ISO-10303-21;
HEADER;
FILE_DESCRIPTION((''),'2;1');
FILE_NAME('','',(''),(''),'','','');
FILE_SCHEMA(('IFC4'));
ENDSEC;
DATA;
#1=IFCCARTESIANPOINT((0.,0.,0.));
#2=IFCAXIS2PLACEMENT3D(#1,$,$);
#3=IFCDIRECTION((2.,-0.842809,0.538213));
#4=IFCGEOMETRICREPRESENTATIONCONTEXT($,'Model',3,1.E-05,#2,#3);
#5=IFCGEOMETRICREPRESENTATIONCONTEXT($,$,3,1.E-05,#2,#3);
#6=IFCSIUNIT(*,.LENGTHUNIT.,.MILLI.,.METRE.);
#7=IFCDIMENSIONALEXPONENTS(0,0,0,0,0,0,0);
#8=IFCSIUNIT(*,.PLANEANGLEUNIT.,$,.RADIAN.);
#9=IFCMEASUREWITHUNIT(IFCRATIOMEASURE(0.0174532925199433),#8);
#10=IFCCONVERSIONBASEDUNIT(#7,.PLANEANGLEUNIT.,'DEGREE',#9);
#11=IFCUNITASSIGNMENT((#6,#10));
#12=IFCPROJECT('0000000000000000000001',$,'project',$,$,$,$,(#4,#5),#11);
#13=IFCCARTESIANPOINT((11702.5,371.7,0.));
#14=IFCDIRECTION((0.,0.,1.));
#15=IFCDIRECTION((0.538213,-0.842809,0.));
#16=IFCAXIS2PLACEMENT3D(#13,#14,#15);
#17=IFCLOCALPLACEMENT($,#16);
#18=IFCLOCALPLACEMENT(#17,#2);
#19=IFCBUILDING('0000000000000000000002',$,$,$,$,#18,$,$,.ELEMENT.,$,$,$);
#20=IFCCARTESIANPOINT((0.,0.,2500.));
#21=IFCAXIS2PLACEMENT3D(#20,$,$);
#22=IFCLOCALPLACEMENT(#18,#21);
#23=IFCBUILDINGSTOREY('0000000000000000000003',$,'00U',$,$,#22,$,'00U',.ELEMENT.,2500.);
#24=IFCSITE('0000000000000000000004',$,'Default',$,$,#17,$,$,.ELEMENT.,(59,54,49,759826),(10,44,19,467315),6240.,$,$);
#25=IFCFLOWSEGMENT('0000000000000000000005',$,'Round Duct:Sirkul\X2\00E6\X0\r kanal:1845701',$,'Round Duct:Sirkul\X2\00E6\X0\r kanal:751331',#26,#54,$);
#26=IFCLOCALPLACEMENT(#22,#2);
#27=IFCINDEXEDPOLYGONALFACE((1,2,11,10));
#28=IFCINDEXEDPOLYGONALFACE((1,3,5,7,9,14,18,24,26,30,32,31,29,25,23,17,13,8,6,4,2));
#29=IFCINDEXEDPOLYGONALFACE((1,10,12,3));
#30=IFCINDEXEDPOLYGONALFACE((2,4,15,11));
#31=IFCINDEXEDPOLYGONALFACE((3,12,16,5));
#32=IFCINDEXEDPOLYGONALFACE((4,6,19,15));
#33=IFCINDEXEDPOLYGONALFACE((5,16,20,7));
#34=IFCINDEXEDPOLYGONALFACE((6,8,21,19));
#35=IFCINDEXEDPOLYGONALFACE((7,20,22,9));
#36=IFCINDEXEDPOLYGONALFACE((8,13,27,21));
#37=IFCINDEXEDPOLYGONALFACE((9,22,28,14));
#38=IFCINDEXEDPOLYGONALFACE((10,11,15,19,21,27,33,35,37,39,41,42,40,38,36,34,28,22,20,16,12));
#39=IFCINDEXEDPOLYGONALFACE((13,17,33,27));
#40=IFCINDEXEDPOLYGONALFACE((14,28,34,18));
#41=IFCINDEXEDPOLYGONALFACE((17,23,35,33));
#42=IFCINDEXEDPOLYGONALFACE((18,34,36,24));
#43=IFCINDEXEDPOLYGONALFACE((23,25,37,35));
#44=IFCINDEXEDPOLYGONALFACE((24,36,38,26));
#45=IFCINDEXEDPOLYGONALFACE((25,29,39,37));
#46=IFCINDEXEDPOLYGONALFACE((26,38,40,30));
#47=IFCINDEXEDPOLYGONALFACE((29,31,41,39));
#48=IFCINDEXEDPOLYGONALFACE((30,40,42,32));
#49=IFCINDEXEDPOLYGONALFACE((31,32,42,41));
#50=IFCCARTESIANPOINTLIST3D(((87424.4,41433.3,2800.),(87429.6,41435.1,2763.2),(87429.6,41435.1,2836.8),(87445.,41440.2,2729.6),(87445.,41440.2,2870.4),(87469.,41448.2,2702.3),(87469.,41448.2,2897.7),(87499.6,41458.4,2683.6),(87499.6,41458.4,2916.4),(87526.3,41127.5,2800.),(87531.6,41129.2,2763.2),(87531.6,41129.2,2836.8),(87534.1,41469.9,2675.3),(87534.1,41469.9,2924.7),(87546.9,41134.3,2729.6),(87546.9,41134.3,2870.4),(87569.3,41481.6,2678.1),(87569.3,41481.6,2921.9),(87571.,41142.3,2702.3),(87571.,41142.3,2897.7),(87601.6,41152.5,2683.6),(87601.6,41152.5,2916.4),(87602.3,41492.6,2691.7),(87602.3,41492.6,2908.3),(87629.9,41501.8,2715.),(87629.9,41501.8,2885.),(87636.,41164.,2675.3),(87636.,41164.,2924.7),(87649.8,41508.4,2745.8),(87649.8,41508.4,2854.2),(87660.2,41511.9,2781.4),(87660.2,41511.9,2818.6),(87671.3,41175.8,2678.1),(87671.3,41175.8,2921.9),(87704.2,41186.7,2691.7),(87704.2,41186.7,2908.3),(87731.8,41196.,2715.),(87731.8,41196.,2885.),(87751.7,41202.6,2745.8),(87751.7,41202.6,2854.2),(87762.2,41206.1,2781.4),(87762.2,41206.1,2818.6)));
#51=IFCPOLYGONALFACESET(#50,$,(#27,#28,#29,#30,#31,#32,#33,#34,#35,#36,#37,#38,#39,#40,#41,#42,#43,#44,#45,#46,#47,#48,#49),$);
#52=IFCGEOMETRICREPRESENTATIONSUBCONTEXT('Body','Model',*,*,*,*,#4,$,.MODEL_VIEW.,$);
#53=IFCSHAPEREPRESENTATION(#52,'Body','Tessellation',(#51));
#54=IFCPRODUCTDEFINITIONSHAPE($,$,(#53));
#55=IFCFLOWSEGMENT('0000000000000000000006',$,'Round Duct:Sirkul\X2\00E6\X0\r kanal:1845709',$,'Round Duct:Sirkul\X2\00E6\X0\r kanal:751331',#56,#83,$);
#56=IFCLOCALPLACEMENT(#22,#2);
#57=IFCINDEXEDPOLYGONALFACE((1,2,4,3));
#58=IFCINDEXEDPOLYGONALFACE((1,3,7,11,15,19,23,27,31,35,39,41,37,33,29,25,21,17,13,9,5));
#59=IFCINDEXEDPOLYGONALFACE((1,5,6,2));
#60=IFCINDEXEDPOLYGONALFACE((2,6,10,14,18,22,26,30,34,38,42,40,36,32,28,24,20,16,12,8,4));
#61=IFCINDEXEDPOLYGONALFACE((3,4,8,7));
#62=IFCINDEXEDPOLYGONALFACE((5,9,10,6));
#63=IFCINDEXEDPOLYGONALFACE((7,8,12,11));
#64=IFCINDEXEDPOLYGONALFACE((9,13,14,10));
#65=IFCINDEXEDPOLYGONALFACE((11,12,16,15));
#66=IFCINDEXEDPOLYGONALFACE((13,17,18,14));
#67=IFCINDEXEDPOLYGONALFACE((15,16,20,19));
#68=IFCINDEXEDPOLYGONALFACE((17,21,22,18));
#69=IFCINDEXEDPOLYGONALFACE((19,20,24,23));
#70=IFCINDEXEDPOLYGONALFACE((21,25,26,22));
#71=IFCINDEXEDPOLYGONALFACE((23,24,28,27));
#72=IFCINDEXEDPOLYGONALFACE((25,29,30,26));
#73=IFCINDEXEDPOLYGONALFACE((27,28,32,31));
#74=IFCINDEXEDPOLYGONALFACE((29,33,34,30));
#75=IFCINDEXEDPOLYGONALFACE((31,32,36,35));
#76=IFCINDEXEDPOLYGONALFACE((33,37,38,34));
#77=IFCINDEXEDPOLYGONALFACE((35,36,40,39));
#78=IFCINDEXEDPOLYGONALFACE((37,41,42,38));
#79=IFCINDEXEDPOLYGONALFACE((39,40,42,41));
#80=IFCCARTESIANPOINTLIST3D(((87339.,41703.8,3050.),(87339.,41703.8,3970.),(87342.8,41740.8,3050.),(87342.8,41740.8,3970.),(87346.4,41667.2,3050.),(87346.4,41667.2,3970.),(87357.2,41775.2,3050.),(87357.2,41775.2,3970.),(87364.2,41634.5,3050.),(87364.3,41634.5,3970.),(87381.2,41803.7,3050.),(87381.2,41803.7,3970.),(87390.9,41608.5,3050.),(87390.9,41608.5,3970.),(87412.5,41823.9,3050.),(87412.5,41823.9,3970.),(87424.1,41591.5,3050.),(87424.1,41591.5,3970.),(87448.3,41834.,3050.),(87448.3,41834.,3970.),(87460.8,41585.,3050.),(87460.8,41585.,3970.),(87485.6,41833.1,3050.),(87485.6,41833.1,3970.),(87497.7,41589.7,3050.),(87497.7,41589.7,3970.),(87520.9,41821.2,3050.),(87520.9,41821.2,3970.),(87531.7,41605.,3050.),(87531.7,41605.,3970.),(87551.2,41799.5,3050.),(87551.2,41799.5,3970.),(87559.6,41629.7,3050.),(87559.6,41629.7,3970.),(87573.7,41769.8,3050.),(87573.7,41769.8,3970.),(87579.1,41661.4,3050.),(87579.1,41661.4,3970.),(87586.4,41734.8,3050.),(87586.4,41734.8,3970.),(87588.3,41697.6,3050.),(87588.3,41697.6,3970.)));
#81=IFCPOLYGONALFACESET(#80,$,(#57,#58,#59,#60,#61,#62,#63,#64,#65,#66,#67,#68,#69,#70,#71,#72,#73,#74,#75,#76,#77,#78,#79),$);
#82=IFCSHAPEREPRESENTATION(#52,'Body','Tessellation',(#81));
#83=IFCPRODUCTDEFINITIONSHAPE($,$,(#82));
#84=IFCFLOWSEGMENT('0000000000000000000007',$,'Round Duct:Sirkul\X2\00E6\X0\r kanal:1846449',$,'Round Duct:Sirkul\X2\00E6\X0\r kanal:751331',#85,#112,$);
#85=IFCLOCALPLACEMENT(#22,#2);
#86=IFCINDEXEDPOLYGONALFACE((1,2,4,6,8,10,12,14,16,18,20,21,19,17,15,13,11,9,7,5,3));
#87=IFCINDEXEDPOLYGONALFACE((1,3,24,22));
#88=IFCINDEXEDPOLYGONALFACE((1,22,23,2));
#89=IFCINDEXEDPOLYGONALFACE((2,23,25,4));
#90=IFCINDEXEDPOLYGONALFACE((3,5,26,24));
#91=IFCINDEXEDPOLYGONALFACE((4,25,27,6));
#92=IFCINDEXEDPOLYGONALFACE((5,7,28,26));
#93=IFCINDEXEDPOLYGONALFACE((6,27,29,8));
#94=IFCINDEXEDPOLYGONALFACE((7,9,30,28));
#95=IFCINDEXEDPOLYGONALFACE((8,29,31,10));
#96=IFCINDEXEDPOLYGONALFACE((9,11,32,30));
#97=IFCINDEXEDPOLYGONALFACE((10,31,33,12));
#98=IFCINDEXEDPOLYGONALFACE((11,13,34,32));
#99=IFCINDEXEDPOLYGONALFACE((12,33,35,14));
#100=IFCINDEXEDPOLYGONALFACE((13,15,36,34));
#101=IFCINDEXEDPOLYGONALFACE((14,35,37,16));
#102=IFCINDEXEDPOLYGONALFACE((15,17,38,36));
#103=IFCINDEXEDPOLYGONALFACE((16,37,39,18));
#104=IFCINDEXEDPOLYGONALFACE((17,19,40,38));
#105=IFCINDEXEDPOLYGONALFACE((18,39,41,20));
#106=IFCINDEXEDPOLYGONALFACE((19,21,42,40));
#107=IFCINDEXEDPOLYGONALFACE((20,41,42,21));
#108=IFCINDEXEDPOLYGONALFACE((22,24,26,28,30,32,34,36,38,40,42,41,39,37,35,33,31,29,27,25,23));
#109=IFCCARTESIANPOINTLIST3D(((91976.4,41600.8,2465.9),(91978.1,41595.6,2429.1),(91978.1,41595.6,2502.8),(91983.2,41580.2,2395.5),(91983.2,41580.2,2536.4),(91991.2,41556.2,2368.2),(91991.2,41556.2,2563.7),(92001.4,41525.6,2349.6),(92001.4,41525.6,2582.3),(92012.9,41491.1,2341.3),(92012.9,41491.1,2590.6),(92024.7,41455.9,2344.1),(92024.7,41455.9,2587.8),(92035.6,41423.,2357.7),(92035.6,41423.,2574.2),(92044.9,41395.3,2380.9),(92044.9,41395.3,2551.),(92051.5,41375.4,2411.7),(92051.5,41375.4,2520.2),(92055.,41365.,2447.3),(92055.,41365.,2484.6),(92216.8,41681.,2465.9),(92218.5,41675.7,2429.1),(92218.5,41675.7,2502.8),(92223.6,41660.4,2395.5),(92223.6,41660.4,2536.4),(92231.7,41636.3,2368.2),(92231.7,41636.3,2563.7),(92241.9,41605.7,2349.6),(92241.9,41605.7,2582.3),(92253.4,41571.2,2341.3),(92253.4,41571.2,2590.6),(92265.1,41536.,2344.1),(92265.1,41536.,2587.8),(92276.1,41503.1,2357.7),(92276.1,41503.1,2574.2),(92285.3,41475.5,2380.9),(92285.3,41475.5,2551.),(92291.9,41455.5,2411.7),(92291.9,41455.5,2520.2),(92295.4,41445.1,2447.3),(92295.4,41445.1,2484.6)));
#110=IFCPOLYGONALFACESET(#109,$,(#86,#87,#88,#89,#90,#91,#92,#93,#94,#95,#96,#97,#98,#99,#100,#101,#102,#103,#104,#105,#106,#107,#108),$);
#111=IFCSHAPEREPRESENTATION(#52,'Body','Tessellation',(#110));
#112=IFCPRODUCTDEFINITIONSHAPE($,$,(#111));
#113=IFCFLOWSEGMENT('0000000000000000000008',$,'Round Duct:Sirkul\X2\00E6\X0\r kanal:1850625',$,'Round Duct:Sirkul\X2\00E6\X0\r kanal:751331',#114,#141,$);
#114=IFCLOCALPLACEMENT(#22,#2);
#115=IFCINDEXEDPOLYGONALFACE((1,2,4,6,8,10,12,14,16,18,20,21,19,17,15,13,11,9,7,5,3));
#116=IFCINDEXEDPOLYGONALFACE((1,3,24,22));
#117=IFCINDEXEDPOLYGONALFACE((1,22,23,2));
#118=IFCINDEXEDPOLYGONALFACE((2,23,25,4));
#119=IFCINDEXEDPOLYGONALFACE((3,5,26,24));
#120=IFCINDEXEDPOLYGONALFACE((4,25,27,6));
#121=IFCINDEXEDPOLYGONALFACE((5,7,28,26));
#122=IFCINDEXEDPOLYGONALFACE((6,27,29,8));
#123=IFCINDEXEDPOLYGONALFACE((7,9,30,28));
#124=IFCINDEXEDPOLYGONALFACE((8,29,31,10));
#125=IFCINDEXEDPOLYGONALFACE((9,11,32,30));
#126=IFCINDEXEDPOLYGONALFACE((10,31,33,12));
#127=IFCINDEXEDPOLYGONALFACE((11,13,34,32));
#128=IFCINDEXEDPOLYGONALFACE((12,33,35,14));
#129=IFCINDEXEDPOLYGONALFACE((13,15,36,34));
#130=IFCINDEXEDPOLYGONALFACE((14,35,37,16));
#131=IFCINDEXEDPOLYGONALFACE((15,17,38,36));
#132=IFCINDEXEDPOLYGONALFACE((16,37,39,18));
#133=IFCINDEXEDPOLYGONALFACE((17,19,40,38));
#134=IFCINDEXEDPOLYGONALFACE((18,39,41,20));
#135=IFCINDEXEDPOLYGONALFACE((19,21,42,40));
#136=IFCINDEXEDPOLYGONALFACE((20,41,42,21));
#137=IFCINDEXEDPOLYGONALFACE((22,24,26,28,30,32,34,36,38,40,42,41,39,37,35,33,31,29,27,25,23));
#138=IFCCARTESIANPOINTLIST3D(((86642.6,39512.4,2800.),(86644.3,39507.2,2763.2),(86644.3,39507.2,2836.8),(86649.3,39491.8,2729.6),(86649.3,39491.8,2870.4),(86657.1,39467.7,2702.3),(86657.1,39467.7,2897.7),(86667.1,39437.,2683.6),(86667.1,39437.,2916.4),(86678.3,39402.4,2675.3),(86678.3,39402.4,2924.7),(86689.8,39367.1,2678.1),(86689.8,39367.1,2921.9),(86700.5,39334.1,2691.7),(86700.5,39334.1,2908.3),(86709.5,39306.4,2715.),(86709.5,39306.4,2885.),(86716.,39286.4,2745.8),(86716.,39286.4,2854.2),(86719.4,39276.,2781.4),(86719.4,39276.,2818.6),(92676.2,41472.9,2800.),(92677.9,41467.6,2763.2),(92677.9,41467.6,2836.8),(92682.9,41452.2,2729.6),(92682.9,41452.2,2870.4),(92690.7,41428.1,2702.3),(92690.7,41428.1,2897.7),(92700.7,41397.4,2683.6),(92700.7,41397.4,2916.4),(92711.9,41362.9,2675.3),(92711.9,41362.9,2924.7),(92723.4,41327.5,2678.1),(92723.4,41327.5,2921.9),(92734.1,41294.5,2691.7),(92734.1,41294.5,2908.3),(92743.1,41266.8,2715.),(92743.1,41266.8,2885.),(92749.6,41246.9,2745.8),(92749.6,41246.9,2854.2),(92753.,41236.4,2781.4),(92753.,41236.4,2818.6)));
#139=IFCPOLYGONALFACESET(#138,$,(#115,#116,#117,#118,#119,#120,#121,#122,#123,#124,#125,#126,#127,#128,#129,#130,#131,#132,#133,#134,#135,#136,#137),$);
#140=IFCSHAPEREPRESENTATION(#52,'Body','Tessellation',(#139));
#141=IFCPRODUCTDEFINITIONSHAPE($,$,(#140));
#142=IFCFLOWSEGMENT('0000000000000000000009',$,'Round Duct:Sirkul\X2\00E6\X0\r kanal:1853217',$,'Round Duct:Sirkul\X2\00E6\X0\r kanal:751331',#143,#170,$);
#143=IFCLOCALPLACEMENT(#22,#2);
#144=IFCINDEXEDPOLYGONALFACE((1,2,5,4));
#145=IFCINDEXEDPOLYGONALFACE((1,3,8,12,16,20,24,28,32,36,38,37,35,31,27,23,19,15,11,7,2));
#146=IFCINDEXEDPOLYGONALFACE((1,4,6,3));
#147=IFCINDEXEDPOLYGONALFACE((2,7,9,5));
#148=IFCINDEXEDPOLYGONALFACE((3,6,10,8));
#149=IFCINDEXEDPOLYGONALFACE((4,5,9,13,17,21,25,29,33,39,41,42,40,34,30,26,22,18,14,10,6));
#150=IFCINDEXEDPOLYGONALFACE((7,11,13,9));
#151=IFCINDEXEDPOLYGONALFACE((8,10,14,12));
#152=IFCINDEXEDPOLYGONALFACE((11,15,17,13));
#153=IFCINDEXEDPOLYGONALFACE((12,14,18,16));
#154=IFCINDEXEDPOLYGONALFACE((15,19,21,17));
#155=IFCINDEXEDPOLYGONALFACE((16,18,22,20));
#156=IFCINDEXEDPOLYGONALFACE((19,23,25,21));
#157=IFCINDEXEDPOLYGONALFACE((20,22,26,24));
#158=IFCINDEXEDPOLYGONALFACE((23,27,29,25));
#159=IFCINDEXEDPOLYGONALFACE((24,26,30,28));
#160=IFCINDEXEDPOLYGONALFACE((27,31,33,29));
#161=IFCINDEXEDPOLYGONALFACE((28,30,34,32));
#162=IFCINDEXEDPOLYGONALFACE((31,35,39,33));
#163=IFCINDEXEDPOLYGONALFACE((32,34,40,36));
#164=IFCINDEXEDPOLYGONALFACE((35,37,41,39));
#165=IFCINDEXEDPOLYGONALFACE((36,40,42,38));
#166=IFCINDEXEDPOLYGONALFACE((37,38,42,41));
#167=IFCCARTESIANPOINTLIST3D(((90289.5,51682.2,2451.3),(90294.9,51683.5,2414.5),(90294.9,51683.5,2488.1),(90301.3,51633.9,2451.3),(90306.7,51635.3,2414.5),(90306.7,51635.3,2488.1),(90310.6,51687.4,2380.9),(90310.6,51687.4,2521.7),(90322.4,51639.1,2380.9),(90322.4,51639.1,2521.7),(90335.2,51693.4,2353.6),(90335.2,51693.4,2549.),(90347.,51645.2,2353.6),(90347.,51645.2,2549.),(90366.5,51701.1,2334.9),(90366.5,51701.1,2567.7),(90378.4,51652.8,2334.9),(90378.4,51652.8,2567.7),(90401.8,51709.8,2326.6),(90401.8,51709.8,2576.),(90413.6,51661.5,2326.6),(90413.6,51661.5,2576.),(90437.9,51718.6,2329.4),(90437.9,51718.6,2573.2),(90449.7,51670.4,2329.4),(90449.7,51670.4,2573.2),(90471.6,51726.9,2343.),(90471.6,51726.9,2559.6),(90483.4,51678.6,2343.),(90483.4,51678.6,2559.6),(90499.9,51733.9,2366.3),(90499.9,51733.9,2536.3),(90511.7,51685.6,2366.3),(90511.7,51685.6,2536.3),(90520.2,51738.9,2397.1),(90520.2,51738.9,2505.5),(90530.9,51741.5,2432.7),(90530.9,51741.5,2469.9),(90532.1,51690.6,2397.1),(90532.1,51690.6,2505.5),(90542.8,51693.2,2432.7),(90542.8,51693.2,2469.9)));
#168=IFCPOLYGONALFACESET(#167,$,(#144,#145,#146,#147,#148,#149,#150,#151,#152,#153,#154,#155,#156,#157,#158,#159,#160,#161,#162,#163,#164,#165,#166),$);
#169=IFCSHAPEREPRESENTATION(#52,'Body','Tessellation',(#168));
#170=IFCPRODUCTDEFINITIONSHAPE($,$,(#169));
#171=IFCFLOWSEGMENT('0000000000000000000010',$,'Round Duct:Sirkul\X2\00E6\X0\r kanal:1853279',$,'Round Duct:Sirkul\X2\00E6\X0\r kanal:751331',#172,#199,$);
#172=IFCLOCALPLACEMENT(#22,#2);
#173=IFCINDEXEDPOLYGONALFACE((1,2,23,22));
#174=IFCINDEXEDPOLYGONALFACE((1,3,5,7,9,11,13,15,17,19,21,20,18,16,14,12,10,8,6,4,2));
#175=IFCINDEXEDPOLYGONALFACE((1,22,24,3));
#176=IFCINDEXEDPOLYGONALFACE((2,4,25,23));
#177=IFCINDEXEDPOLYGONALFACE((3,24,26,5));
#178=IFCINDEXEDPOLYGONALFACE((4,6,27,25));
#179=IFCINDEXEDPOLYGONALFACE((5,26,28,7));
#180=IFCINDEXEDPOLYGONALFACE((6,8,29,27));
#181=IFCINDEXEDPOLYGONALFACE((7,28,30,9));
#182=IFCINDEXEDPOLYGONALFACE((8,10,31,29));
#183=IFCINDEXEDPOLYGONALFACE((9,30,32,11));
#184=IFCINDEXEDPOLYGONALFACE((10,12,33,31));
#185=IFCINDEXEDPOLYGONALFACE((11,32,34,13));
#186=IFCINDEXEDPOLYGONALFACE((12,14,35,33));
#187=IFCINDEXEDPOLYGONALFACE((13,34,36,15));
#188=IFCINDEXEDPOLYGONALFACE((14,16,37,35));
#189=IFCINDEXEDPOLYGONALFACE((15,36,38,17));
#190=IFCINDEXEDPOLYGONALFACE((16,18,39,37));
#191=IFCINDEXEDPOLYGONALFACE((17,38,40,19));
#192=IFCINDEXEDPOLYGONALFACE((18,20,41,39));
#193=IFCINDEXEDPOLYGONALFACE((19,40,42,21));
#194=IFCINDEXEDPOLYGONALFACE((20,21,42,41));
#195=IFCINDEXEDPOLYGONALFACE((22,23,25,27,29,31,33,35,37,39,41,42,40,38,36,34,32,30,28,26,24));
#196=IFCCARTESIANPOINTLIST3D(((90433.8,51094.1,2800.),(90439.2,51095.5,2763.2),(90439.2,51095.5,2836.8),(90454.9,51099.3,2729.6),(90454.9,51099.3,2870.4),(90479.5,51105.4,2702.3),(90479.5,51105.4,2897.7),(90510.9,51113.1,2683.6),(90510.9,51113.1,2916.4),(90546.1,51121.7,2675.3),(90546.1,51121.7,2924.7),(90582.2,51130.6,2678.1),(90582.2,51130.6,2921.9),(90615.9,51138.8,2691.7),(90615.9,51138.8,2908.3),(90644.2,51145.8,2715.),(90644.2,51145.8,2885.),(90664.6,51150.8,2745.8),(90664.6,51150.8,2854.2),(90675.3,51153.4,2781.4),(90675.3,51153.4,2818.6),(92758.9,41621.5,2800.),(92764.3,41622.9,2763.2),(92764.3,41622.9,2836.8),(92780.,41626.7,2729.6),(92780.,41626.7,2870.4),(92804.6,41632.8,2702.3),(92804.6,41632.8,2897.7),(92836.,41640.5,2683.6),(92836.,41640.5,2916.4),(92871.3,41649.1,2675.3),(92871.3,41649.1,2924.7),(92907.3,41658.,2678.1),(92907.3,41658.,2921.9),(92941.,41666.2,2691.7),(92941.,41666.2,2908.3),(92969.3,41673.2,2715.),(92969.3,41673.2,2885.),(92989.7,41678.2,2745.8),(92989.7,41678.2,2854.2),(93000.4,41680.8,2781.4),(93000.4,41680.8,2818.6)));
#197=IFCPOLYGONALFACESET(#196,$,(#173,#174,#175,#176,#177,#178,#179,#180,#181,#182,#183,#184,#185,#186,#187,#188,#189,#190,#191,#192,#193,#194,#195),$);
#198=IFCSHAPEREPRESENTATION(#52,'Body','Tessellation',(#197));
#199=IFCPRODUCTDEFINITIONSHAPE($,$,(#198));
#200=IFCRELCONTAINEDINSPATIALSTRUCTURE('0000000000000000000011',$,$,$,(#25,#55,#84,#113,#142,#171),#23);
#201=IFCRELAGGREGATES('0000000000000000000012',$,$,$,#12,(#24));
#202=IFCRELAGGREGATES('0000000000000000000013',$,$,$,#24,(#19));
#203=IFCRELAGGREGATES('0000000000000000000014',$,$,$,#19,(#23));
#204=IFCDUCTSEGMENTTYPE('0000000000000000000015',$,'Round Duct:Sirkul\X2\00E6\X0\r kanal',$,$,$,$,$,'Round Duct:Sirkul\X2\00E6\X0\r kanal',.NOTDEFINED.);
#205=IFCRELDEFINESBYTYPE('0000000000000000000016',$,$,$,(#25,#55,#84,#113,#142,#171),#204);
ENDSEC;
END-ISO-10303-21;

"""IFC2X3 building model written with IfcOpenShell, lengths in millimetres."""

from ifc_helpers import new_model, entity, si_unit, converted_unit, direction, frame, origin, origin_2d_with_axis, place, context, subcontext, project, spatial, circle, extrude, type_object, element, save


model = new_model("IFC2X3")

# Units and contexts
model_context = context("Model", 3, precision=1e-05, world=origin(), true_north=direction((2.0, -0.842809, 0.538213)))
context_of_model = context(None, 3, precision=1e-05, world=origin(), true_north=direction((2.0, -0.842809, 0.538213)))
body_context = subcontext(model_context, "Body", "Model", "MODEL_VIEW")
ifc_project = project(units=[si_unit("LENGTHUNIT", "METRE", prefix="MILLI"), converted_unit("PLANEANGLEUNIT", "DEGREE", entity("IfcRatioMeasure", 0.0174532925199433), si_unit("PLANEANGLEUNIT", "RADIAN"), dimensions=[0, 0, 0, 0, 0, 0, 0])], contexts=[model_context, context_of_model])

# Site, building, storey
site_placement = place(None, frame((11702.5, 371.7, 0.0), z_axis=(0.0, 0.0, 1.0), x_axis=(0.538213, -0.842809, 0.0)))
site = spatial("IfcSite", under=ifc_project, at=site_placement, Name="Default", CompositionType="ELEMENT", RefLatitude=(59, 54, 49, 759826), RefLongitude=(10, 44, 19, 467315), RefElevation=6240.0)
building_placement = place(site_placement, origin())
building = spatial("IfcBuilding", under=site, at=building_placement, CompositionType="ELEMENT")
storey_placement = place(building_placement, frame((0.0, 0.0, 2500.0)))
storey = spatial("IfcBuildingStorey", under=building, at=storey_placement, Name="00U", LongName="00U", CompositionType="ELEMENT", Elevation=2500.0)

# Flow segments
duct_segment_type = type_object("IfcDuctSegmentType", Name="Round Duct:Sirkulær kanal", ElementType="Round Duct:Sirkulær kanal", PredefinedType="NOTDEFINED")
flow_segment_1_placement = place(storey_placement, origin())
element("IfcFlowSegment", 1, at=flow_segment_1_placement, inside=storey, type_object=duct_segment_type, Name="Round Duct:Sirkulær kanal:1845701", ObjectType="Round Duct:Sirkulær kanal:751331", context=body_context, shape_type="SweptSolid", body=[
    extrude(circle(Radius=125.0, at=origin_2d_with_axis()), frame((87543.0, 41472.8, 2800.0), z_axis=(0.316197, -0.948693, 0.0), x_axis=(-0.948693, -0.316197, 0.0)), (0.0, 0.0, 1.0), 322.4),
])
flow_segment_2_placement = place(storey_placement, origin())
element("IfcFlowSegment", 2, at=flow_segment_2_placement, inside=storey, type_object=duct_segment_type, Name="Round Duct:Sirkulær kanal:1845709", ObjectType="Round Duct:Sirkulær kanal:751331", context=body_context, shape_type="SweptSolid", body=[
    extrude(circle(Radius=125.0, at=origin_2d_with_axis()), frame((87463.9, 41710.0, 3050.0), z_axis=(0.000002, 0.000001, 1.0), x_axis=(-0.939693, -0.34202, 0.000002)), (0.0, 0.0, 1.0), 920.0),
])
flow_segment_3_placement = place(storey_placement, origin())
element("IfcFlowSegment", 3, at=flow_segment_3_placement, inside=storey, type_object=duct_segment_type, Name="Round Duct:Sirkulær kanal:1846449", ObjectType="Round Duct:Sirkulær kanal:751331", context=body_context, shape_type="SweptSolid", body=[
    extrude(circle(Radius=125.0, at=origin_2d_with_axis()), frame((92015.9, 41482.2, 2465.9), z_axis=(0.948687, 0.316216, 0.0), x_axis=(-0.316216, 0.948687, 0.0)), (0.0, 0.0, 1.0), 253.4),
])
flow_segment_4_placement = place(storey_placement, origin())
element("IfcFlowSegment", 4, at=flow_segment_4_placement, inside=storey, type_object=duct_segment_type, Name="Round Duct:Sirkulær kanal:1850625", ObjectType="Round Duct:Sirkulær kanal:751331", context=body_context, shape_type="SweptSolid", body=[
    extrude(circle(Radius=125.0, at=origin_2d_with_axis()), frame((86681.2, 39393.6, 2800.0), z_axis=(0.951057, 0.309017, 0.0), x_axis=(-0.309017, 0.951057, 0.0)), (0.0, 0.0, 1.0), 6344.1),
])
flow_segment_5_placement = place(storey_placement, origin())
element("IfcFlowSegment", 5, at=flow_segment_5_placement, inside=storey, type_object=duct_segment_type, Name="Round Duct:Sirkulær kanal:1853217", ObjectType="Round Duct:Sirkulær kanal:751331", context=body_context, shape_type="SweptSolid", body=[
    extrude(circle(Radius=125.0, at=origin_2d_with_axis()), frame((90410.9, 51712.0, 2451.3), z_axis=(0.238381, -0.971172, 0.0), x_axis=(-0.971172, -0.238381, 0.0)), (0.0, 0.0, 1.0), 49.7),
])
flow_segment_6_placement = place(storey_placement, origin())
element("IfcFlowSegment", 6, at=flow_segment_6_placement, inside=storey, type_object=duct_segment_type, Name="Round Duct:Sirkulær kanal:1853279", ObjectType="Round Duct:Sirkulær kanal:751331", context=body_context, shape_type="SweptSolid", body=[
    extrude(circle(Radius=125.0, at=origin_2d_with_axis()), frame((92880.3, 41651.3, 2800.0), z_axis=(-0.238381, 0.971172, 0.0), x_axis=(-0.971172, -0.238381, 0.0)), (0.0, 0.0, 1.0), 9753.8),
])

save(model, "model.ifc")
